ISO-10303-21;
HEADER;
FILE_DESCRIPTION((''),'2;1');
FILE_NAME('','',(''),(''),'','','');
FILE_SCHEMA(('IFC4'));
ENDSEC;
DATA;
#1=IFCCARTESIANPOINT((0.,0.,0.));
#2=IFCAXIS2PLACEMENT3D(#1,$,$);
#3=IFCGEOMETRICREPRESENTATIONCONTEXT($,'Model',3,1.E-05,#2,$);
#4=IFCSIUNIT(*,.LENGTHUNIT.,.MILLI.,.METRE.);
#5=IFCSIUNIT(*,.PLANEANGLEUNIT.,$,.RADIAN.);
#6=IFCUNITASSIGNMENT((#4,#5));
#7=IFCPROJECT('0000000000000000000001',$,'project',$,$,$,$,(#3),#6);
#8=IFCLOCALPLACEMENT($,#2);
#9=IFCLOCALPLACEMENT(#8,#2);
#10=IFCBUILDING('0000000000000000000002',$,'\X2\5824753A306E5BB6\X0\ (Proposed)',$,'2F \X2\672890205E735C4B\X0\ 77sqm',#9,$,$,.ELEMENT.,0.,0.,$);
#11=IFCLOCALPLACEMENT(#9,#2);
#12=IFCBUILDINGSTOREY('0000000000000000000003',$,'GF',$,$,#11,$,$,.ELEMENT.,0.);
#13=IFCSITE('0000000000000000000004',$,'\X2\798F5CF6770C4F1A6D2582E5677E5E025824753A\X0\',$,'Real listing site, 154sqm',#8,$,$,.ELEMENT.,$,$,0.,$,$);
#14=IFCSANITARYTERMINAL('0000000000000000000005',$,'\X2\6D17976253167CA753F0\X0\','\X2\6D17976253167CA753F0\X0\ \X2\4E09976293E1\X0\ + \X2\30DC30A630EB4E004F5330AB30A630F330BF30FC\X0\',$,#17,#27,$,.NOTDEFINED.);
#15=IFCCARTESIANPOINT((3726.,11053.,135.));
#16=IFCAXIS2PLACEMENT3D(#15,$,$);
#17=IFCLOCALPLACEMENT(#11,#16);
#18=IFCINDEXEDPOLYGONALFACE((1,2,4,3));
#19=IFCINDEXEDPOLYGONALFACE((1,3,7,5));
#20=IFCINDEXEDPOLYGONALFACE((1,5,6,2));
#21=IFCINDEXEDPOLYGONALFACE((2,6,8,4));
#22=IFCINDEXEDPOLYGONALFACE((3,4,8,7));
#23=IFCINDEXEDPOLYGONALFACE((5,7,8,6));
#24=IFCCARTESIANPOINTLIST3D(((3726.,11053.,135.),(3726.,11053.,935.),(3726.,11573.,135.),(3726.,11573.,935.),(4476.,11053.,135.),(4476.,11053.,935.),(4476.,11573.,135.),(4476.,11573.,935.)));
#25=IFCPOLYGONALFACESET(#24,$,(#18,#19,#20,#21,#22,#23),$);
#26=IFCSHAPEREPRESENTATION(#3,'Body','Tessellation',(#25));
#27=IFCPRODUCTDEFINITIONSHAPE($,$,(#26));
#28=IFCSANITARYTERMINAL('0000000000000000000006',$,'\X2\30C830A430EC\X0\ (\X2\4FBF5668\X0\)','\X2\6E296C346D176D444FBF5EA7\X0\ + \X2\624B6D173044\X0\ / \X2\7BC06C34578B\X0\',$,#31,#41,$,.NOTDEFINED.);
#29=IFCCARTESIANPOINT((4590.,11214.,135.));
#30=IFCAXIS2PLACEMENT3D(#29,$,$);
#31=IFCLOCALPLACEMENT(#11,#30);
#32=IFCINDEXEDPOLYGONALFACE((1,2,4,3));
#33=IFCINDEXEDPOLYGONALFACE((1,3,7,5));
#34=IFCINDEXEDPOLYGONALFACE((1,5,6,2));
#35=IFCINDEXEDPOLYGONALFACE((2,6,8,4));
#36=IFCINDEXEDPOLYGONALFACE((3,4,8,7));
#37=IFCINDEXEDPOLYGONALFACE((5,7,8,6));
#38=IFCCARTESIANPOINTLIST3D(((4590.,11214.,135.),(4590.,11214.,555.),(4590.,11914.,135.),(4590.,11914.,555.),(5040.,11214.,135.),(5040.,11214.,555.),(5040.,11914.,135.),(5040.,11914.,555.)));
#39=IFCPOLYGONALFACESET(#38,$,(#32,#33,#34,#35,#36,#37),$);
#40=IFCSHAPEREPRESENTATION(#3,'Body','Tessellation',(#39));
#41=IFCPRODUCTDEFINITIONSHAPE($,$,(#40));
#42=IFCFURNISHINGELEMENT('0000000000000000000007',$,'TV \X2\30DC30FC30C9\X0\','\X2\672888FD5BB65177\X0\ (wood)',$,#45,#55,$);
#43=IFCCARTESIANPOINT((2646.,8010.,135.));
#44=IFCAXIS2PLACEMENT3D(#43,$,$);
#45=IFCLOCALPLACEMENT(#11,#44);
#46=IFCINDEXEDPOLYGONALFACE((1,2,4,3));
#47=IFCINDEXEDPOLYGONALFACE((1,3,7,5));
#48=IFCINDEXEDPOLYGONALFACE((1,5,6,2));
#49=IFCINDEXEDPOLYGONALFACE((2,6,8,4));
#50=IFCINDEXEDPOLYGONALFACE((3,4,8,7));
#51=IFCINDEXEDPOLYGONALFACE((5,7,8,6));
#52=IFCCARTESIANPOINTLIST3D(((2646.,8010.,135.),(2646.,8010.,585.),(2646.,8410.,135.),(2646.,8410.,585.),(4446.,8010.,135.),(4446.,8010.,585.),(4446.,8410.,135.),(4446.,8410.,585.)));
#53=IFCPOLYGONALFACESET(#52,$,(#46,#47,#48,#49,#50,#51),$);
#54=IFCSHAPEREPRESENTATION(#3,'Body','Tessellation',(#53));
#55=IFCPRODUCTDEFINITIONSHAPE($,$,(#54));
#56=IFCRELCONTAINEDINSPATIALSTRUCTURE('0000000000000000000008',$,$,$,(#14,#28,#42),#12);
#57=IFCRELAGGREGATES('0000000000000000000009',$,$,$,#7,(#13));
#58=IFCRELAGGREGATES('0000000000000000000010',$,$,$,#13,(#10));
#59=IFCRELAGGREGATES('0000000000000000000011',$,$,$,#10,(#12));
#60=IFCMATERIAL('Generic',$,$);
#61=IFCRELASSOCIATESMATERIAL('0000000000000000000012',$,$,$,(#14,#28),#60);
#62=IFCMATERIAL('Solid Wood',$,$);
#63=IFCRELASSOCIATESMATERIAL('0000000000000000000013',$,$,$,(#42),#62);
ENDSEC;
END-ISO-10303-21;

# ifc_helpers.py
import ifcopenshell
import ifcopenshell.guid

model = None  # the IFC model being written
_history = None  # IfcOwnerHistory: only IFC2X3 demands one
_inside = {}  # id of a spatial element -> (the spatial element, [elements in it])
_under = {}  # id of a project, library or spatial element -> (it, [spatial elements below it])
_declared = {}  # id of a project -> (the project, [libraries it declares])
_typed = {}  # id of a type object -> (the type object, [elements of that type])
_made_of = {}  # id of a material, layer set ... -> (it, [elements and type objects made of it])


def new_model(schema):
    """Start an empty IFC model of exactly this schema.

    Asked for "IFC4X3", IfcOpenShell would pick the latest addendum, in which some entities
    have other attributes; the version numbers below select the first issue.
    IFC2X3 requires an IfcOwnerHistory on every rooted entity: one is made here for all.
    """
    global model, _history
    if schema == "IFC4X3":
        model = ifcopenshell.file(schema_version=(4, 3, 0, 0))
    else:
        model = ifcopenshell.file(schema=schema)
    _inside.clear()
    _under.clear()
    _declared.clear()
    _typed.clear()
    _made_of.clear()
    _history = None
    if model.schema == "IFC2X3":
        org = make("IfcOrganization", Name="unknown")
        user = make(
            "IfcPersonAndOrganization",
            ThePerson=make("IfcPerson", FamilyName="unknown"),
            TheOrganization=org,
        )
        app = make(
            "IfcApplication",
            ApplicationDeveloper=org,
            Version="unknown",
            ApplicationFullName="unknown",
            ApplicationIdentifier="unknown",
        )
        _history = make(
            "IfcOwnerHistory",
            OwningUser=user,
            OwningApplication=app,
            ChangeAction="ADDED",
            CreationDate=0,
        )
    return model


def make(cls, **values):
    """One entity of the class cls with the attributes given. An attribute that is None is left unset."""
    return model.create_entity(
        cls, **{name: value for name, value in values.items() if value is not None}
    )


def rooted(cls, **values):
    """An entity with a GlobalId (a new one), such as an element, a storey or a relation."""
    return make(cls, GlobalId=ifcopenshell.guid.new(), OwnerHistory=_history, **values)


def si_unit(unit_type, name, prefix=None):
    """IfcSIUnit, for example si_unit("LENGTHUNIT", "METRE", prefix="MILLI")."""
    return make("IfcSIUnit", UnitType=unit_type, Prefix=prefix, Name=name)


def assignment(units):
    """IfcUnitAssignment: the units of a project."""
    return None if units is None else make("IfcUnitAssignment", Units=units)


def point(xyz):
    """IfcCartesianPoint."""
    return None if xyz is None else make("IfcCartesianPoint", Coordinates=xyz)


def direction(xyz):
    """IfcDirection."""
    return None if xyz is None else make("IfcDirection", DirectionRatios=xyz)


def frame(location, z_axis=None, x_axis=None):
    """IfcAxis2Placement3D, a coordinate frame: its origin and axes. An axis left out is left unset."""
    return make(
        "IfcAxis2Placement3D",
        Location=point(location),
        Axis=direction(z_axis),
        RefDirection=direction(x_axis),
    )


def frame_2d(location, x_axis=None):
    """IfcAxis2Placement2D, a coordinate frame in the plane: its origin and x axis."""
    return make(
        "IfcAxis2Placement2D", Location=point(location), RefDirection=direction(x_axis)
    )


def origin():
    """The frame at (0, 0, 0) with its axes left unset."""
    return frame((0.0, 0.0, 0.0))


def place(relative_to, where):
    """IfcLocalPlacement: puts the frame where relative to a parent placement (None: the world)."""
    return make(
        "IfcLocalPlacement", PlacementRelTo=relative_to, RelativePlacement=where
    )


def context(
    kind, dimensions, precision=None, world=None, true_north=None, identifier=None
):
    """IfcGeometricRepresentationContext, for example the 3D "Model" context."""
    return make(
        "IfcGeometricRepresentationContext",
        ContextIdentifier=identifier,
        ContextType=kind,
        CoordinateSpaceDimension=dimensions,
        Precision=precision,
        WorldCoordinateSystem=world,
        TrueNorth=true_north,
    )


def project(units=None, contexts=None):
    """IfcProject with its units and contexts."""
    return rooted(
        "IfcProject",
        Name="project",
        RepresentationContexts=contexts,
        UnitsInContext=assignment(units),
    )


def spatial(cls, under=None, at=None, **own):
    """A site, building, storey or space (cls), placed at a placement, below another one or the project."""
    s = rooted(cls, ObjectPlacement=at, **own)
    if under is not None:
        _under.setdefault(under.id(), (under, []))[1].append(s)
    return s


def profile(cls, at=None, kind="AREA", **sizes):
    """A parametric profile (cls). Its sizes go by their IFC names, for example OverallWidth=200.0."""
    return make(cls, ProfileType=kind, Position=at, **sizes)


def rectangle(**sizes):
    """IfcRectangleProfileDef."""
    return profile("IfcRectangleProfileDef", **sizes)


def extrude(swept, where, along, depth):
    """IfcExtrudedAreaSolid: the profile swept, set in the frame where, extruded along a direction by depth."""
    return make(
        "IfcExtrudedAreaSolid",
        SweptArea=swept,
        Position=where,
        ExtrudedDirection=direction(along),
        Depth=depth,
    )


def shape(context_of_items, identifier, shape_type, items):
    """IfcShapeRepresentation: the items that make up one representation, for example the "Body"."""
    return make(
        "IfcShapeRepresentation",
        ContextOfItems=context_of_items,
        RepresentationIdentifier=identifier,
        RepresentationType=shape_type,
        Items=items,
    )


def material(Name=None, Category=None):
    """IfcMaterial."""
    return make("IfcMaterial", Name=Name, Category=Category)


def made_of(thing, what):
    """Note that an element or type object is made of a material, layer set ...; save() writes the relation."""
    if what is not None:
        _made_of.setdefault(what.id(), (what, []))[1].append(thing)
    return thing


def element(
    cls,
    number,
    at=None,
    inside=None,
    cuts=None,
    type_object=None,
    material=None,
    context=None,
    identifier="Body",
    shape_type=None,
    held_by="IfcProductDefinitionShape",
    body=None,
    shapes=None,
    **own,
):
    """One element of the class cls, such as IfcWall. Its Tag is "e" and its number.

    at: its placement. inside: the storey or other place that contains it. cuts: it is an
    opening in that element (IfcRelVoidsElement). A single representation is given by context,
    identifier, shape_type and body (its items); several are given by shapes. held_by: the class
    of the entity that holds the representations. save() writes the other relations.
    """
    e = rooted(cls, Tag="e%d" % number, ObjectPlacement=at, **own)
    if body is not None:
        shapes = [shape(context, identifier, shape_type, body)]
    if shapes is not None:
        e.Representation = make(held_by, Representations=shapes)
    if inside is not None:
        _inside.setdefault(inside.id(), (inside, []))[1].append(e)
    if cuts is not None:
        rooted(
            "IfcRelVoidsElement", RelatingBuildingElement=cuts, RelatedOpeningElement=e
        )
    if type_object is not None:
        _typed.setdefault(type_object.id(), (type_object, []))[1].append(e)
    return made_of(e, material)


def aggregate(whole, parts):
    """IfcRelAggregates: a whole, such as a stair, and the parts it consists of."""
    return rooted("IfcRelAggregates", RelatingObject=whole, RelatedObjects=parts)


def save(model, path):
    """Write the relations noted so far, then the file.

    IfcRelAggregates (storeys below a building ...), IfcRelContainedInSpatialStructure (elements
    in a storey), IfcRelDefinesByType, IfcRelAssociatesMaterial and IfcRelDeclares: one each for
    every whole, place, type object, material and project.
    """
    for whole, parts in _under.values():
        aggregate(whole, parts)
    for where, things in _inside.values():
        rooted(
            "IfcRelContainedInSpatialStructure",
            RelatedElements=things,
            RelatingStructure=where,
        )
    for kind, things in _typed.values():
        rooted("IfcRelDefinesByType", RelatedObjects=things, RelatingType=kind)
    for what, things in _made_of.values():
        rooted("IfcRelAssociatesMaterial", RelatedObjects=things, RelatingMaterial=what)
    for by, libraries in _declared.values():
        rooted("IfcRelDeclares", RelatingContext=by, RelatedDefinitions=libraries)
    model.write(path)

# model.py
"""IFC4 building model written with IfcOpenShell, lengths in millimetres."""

from ifc_helpers import new_model, si_unit, frame, frame_2d, origin, place, context, project, spatial, rectangle, extrude, material, element, save


model = new_model("IFC4")

# Units and contexts
model_context = context("Model", 3, precision=1e-05, world=origin())
ifc_project = project(units=[si_unit("LENGTHUNIT", "METRE", prefix="MILLI"), si_unit("PLANEANGLEUNIT", "RADIAN")], contexts=[model_context])

# Site, building, storey
site_placement = place(None, origin())
site = spatial("IfcSite", under=ifc_project, at=site_placement, Name="福島県会津若松市堤町", ObjectType="Real listing site, 154sqm", CompositionType="ELEMENT", RefElevation=0.0)
building_placement = place(site_placement, origin())
building = spatial("IfcBuilding", under=site, at=building_placement, Name="堤町の家 (Proposed)", ObjectType="2F 木造平屋 77sqm", CompositionType="ELEMENT", ElevationOfRefHeight=0.0, ElevationOfTerrain=0.0)
storey_placement = place(building_placement, origin())
storey = spatial("IfcBuildingStorey", under=building, at=storey_placement, Name="GF", CompositionType="ELEMENT", Elevation=0.0)

# Shared definitions
ifc_material_1 = material(Name="Solid Wood")

# Shared definitions
ifc_material_2 = material(Name="Generic")

# Sanitary terminals
sanitary_terminal_1_placement = place(storey_placement, frame((3726.0, 11053.0, 135.0)))
element("IfcSanitaryTerminal", 1, at=sanitary_terminal_1_placement, inside=storey, material=ifc_material_2, Name="洗面化粧台", Description="洗面化粧台 三面鏡 + ボウル一体カウンター", PredefinedType="NOTDEFINED", context=model_context, shape_type="SweptSolid", body=[
    extrude(rectangle(XDim=750.0, YDim=520.0, at=frame_2d((375.0, 260.0))), frame((3726.0, 11053.0, 135.0)), (0.0, 0.0, 1.0), 800.0),
])
sanitary_terminal_2_placement = place(storey_placement, frame((4590.0, 11214.0, 135.0)))
element("IfcSanitaryTerminal", 2, at=sanitary_terminal_2_placement, inside=storey, material=ifc_material_2, Name="トイレ (便器)", Description="温水洗浄便座 + 手洗い / 節水型", PredefinedType="NOTDEFINED", context=model_context, shape_type="SweptSolid", body=[
    extrude(rectangle(XDim=450.0, YDim=700.0, at=frame_2d((225.0, 350.0))), frame((4590.0, 11214.0, 135.0)), (0.0, 0.0, 1.0), 420.0),
])

# Furnishing element
furnishing_placement = place(storey_placement, frame((2646.0, 8010.0, 135.0)))
element("IfcFurnishingElement", 3, at=furnishing_placement, inside=storey, material=ifc_material_1, Name="TV ボード", Description="木製家具 (wood)", context=model_context, shape_type="SweptSolid", body=[
    extrude(rectangle(XDim=1800.0, YDim=400.0, at=frame_2d((900.0, 200.0))), frame((2646.0, 8010.0, 135.0)), (0.0, 0.0, 1.0), 450.0),
])

save(model, "model.ifc")
